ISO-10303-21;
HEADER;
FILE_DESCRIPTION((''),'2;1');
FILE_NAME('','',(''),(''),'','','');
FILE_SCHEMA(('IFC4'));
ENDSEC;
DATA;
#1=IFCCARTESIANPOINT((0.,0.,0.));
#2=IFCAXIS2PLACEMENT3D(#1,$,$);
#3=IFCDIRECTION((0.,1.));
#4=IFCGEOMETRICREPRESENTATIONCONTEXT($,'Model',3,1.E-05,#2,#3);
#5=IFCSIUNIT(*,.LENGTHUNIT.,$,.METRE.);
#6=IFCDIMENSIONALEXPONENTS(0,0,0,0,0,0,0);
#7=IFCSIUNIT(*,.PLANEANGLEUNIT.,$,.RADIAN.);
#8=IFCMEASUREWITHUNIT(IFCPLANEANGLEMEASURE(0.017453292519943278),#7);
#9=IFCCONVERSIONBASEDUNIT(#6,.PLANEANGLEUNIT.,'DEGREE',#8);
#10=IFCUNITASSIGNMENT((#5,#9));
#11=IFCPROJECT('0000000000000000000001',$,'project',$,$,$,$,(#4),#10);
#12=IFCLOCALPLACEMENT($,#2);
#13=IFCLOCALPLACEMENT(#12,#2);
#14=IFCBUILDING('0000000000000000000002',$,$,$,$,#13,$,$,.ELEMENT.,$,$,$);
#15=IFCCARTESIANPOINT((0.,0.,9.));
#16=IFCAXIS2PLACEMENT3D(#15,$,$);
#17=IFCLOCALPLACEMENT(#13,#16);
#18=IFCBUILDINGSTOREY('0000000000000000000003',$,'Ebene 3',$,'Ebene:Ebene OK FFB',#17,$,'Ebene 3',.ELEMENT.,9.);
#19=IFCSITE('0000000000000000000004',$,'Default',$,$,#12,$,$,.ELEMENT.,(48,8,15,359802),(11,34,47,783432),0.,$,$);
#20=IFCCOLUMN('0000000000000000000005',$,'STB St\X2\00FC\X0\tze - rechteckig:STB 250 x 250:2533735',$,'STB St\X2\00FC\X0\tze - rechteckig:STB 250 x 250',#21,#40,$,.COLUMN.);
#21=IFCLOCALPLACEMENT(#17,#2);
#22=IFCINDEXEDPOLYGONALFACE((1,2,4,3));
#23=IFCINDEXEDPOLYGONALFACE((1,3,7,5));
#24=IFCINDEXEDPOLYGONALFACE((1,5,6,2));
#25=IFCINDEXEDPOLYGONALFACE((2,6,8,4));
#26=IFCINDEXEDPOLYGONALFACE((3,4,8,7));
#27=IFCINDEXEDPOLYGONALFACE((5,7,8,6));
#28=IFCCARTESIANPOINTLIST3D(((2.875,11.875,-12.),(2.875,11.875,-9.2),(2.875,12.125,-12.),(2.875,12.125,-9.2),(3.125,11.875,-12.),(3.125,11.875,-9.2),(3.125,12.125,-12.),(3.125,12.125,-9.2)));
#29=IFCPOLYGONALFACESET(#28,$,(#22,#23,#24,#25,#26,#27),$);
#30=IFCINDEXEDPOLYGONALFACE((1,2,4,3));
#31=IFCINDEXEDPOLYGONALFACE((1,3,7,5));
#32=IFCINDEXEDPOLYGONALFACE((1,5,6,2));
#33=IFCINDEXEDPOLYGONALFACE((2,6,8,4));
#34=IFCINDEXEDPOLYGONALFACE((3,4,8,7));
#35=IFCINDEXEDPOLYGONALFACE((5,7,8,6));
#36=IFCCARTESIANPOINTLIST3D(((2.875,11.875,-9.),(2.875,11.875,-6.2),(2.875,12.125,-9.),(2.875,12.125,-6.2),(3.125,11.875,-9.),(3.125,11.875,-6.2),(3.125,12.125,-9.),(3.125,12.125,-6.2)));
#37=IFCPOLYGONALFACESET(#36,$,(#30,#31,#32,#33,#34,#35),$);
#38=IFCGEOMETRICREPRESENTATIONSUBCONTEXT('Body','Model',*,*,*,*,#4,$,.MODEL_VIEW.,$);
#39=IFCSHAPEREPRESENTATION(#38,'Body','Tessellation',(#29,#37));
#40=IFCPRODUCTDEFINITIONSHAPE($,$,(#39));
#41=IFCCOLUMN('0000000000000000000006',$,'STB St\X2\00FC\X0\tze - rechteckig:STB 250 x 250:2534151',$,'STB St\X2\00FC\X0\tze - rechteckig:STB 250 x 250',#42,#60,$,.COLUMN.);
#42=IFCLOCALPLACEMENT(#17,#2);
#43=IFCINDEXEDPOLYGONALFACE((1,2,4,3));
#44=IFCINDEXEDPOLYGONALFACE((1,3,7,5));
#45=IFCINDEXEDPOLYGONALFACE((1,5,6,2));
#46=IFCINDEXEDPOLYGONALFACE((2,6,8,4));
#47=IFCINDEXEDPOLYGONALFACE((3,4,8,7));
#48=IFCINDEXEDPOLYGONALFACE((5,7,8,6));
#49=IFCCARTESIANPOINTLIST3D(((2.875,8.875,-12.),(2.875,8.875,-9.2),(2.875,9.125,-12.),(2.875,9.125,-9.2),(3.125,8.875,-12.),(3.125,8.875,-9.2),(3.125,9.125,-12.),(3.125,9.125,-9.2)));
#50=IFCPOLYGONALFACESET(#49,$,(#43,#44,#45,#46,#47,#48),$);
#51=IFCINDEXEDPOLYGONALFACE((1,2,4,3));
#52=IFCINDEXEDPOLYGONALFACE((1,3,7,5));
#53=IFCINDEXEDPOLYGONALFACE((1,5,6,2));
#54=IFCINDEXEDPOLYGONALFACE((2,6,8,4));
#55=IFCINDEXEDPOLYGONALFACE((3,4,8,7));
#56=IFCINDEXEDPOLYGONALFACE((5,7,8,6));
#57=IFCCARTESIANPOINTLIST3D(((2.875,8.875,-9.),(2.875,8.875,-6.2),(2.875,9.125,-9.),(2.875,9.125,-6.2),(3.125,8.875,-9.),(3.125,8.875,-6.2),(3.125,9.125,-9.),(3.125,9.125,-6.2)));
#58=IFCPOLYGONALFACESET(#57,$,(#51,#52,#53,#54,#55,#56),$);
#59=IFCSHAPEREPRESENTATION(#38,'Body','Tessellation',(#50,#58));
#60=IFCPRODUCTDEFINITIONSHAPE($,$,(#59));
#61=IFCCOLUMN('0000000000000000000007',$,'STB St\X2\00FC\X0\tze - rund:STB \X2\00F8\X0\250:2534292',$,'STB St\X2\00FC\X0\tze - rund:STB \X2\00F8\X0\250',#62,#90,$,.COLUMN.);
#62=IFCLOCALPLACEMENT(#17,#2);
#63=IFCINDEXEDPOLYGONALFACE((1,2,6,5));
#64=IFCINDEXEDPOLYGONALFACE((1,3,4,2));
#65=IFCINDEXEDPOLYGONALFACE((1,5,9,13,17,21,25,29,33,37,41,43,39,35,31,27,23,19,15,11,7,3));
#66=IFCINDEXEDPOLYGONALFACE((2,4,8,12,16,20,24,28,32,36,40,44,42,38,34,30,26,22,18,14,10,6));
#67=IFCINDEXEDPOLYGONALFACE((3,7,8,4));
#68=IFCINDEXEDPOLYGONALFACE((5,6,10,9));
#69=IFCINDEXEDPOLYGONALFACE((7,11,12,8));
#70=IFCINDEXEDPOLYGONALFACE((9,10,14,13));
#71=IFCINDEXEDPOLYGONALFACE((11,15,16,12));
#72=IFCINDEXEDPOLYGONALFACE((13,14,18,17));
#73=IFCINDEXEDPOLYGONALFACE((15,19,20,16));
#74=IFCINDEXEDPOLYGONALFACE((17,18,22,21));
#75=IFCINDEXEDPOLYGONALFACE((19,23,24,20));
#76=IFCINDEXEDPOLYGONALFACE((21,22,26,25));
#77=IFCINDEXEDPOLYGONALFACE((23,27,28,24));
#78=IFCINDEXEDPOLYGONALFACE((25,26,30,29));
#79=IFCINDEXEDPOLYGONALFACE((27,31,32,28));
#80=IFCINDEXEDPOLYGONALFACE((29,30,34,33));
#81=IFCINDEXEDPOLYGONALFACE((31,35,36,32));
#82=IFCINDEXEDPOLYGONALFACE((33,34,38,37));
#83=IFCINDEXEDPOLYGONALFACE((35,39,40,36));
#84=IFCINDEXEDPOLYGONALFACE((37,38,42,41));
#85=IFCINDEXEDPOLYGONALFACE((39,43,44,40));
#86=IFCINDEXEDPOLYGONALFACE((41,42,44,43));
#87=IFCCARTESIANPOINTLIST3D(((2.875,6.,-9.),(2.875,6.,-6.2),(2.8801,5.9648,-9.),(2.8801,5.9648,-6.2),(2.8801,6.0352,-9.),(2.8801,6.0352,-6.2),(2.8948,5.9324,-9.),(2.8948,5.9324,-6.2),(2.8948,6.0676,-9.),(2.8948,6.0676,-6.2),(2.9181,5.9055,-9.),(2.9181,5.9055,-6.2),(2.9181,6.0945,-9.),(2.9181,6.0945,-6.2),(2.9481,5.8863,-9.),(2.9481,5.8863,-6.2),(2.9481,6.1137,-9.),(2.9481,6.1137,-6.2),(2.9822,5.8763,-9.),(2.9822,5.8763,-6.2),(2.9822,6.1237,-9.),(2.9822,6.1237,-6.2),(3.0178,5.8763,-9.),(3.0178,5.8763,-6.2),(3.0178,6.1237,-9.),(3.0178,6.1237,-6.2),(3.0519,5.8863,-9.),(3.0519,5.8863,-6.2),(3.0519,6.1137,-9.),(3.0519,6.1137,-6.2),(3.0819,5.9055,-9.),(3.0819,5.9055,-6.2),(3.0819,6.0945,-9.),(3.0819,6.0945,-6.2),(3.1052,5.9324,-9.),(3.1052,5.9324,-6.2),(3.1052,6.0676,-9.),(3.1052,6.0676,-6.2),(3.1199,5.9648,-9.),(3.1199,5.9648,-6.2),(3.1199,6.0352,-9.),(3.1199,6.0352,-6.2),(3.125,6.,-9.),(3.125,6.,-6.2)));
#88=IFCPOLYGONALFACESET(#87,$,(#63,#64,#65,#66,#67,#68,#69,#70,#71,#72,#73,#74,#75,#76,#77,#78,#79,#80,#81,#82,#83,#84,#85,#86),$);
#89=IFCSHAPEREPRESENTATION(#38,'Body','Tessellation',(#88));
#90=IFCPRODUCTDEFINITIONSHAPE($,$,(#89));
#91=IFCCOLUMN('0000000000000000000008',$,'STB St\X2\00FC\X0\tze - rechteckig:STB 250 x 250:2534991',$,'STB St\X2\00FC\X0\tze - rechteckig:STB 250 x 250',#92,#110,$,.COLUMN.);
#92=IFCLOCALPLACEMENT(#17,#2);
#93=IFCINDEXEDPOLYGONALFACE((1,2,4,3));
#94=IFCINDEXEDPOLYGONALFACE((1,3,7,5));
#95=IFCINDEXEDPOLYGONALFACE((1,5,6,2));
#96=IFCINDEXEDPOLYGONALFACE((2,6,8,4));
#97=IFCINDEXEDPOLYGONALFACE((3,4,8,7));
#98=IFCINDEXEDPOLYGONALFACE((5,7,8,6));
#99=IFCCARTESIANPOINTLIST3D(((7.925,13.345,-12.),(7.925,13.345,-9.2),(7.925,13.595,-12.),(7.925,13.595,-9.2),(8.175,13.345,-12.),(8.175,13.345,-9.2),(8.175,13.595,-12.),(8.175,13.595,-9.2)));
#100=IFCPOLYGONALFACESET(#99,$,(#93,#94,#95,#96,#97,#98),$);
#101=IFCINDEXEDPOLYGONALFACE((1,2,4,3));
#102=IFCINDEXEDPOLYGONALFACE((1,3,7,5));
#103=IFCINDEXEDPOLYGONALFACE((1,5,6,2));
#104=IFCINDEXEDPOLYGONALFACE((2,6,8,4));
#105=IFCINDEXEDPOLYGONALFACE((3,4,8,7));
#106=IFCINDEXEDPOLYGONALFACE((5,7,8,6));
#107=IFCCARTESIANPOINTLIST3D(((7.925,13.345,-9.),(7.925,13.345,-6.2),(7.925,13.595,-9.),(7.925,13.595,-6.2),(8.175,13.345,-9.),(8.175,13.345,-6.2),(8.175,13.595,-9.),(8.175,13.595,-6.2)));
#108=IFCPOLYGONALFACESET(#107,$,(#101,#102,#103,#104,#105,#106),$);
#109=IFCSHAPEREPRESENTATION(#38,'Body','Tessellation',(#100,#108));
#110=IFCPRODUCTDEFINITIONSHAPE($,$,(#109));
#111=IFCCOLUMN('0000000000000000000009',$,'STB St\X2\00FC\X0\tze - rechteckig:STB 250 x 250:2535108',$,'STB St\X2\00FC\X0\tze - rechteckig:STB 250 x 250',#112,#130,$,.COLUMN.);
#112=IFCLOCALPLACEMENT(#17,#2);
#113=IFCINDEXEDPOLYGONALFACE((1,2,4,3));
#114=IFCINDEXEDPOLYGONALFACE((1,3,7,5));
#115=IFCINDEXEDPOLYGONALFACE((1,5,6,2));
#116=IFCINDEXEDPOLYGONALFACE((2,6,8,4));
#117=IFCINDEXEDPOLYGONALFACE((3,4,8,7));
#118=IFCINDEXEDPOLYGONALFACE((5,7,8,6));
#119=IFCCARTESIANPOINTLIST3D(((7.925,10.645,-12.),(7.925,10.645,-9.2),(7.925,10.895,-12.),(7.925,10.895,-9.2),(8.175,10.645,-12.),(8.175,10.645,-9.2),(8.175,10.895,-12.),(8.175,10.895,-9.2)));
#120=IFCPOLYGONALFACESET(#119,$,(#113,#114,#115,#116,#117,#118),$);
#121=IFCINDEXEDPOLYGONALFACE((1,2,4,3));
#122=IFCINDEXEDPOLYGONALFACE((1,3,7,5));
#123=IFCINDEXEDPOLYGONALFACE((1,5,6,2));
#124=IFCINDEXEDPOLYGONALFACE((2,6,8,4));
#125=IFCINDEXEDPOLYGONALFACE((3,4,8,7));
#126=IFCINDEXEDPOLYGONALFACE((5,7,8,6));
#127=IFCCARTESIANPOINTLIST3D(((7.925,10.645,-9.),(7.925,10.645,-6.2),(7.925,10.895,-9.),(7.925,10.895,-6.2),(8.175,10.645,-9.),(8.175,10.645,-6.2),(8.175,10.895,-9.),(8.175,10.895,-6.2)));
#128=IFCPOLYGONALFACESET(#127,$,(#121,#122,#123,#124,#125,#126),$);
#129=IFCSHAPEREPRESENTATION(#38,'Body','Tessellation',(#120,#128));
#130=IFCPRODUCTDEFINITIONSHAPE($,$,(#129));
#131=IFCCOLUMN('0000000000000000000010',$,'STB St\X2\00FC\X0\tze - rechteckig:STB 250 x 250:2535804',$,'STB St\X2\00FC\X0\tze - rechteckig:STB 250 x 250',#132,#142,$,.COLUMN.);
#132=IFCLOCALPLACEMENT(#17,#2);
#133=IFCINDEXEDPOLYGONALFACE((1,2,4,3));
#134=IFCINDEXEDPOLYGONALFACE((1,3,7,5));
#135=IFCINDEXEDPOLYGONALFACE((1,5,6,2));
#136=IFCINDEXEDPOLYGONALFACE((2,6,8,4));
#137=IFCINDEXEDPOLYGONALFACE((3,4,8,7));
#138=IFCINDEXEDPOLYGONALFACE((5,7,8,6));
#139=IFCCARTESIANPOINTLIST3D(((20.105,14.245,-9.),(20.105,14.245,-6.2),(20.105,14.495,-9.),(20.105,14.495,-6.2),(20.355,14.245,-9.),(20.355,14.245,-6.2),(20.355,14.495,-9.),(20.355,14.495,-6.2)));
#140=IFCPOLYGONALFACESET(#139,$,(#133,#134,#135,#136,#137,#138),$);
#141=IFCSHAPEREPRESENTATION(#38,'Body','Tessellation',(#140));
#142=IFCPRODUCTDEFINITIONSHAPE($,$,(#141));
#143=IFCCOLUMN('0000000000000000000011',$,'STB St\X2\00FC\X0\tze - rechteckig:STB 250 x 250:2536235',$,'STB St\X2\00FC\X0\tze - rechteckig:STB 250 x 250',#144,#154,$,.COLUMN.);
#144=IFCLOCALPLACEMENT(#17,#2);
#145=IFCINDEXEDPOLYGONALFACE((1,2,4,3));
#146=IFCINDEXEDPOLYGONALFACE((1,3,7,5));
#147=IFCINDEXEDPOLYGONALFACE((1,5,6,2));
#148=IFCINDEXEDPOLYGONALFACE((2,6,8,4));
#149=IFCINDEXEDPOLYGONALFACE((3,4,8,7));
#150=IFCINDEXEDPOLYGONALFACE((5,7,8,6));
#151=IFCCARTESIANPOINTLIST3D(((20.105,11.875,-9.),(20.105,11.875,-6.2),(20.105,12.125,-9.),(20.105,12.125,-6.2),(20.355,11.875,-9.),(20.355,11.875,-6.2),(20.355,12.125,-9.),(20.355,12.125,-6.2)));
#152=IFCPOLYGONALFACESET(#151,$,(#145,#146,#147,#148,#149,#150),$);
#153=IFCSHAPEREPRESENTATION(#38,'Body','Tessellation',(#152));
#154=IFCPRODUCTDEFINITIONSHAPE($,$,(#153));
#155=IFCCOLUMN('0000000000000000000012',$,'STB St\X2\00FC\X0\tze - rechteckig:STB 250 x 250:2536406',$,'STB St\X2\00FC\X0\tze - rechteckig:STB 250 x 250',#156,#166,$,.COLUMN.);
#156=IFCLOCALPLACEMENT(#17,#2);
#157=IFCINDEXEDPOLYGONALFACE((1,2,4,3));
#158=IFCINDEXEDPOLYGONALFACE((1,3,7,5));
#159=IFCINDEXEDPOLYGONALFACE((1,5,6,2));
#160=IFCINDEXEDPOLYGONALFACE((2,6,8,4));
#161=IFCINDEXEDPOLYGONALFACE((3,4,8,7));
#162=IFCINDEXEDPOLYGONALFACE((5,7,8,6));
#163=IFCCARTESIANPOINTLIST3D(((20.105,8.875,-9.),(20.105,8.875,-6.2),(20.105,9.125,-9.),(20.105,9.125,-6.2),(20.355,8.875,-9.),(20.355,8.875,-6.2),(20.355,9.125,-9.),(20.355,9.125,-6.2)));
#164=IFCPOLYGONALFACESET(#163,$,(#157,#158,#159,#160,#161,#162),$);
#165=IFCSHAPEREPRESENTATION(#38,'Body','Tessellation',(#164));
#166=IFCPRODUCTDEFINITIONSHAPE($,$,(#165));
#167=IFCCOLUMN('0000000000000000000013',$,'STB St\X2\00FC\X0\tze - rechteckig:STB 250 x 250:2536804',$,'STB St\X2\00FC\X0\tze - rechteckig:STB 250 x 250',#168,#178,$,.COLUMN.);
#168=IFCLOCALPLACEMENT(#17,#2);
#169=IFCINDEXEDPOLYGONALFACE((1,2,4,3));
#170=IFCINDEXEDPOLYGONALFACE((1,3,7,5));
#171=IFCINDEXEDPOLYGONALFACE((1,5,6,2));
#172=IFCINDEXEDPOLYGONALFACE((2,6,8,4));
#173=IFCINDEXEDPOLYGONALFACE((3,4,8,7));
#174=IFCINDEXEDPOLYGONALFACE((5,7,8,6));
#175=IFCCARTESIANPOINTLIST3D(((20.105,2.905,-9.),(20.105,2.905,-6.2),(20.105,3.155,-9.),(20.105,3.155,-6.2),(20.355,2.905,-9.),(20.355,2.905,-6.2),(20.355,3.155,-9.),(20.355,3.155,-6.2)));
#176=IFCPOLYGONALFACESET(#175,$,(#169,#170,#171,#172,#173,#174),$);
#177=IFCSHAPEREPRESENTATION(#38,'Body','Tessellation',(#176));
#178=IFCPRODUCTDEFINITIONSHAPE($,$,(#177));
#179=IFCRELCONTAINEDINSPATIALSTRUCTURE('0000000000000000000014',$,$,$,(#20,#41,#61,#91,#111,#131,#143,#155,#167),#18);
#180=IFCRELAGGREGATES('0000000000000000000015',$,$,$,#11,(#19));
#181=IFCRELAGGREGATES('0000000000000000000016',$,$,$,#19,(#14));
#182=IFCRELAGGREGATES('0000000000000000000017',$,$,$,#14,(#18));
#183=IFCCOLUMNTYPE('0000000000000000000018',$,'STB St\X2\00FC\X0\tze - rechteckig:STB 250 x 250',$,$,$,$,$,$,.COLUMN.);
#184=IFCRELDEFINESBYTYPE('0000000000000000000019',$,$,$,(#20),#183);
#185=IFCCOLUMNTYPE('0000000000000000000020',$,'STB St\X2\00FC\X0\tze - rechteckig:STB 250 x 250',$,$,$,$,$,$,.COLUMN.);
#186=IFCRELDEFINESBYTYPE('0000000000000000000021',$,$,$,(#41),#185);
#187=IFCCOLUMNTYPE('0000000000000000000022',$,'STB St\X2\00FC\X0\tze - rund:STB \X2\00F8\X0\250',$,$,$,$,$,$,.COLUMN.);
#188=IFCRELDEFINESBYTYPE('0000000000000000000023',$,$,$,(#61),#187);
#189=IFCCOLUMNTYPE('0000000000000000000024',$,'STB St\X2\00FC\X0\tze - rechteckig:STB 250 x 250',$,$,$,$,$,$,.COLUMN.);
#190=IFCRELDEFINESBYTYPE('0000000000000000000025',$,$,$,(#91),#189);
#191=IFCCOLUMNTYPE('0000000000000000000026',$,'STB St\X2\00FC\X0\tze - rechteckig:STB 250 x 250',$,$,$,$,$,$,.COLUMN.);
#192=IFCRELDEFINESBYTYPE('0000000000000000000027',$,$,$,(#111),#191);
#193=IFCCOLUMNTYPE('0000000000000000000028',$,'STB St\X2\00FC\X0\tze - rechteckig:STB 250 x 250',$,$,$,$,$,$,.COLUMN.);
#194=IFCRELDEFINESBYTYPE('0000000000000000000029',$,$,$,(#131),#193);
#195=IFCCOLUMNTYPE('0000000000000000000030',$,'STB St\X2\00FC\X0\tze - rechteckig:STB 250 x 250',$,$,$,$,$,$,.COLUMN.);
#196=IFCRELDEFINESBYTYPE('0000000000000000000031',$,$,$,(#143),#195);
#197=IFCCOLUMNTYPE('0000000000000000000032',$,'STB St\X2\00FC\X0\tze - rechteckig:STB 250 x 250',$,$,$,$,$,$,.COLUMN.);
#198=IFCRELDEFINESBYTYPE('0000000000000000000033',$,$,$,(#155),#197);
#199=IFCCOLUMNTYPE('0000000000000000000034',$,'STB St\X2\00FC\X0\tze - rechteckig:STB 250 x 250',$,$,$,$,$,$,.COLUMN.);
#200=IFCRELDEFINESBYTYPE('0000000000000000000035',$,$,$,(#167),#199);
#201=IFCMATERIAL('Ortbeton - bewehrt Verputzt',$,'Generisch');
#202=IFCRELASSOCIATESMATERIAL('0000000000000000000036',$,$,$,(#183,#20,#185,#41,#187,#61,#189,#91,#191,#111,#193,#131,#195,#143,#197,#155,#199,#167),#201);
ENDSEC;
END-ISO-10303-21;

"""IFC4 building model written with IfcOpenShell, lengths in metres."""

from ifc_helpers import new_model, entity, si_unit, converted_unit, direction, frame, origin, place, context, subcontext, project, spatial, arc, indexed_curve, outline, extrude, source, transform, mapped, material, type_object, type_shapes, element, save


model = new_model("IFC4")

# Units and contexts
model_context = context("Model", 3, precision=1e-05, world=origin(), true_north=direction((0.0, 1.0)))
body_context = subcontext(model_context, "Body", "Model", "MODEL_VIEW")
ifc_project = project(units=[si_unit("LENGTHUNIT", "METRE"), converted_unit("PLANEANGLEUNIT", "DEGREE", entity("IfcPlaneAngleMeasure", 0.017453292519943278), si_unit("PLANEANGLEUNIT", "RADIAN"), dimensions=[0, 0, 0, 0, 0, 0, 0])], contexts=[model_context])

# Site, building, storey
site_placement = place(None, origin())
site = spatial("IfcSite", under=ifc_project, at=site_placement, Name="Default", CompositionType="ELEMENT", RefLatitude=(48, 8, 15, 359802), RefLongitude=(11, 34, 47, 783432), RefElevation=0.0)
building_placement = place(site_placement, origin())
building = spatial("IfcBuilding", under=site, at=building_placement, CompositionType="ELEMENT")
storey_placement = place(building_placement, frame((0.0, 0.0, 9.0)))
storey = spatial("IfcBuildingStorey", under=building, at=storey_placement, Name="Ebene 3", ObjectType="Ebene:Ebene OK FFB", LongName="Ebene 3", CompositionType="ELEMENT", Elevation=9.0)

# Columns
ifc_material_1 = material(Name="Ortbeton - bewehrt Verputzt", Category="Generisch")
column_type_1 = type_object("IfcColumnType", Name="STB Stütze - rechteckig:STB 250 x 250", PredefinedType="COLUMN", material=ifc_material_1)
shared_shape_1 = source(origin(), body_context, "Body", "SweptSolid", [
    extrude(outline(indexed_curve([(-0.125, -0.125), (0.125, -0.125), (0.125, 0.125), (-0.125, 0.125), (-0.125, -0.125)], self_intersect=False)), frame((3.0, 12.0, -3.0), z_axis=(0.0, 0.0, 1.0), x_axis=(-1.0, 0.0, 0.0)), (0.0, 0.0, 1.0), 2.8),
    extrude(outline(indexed_curve([(-0.125, -0.125), (0.125, -0.125), (0.125, 0.125), (-0.125, 0.125), (-0.125, -0.125)], self_intersect=False)), frame((3.0, 12.0, 0.0), z_axis=(0.0, 0.0, 1.0), x_axis=(0.0, -1.0, 0.0)), (0.0, 0.0, 1.0), 2.8),
])
type_shapes(column_type_1, [shared_shape_1])
column_1_placement = place(storey_placement, frame((0.0, 0.0, -9.0)))
element("IfcColumn", 1, at=column_1_placement, inside=storey, type_object=column_type_1, material=ifc_material_1, Name="STB Stütze - rechteckig:STB 250 x 250:2533735", ObjectType="STB Stütze - rechteckig:STB 250 x 250", PredefinedType="COLUMN", context=body_context, shape_type="MappedRepresentation", body=[
    mapped(shared_shape_1, transform((0.0, 0.0, 0.0), scale=1.0)),
])
column_type_2 = type_object("IfcColumnType", Name="STB Stütze - rechteckig:STB 250 x 250", PredefinedType="COLUMN", material=ifc_material_1)
shared_shape_2 = source(origin(), body_context, "Body", "SweptSolid", [
    extrude(outline(indexed_curve([(-0.125, -0.125), (0.125, -0.125), (0.125, 0.125), (-0.125, 0.125), (-0.125, -0.125)], self_intersect=False)), frame((3.0, 9.0, -3.0), z_axis=(0.0, 0.0, 1.0), x_axis=(-1.0, 0.0, 0.0)), (0.0, 0.0, 1.0), 2.8),
    extrude(outline(indexed_curve([(-0.125, -0.125), (0.125, -0.125), (0.125, 0.125), (-0.125, 0.125), (-0.125, -0.125)], self_intersect=False)), frame((3.0, 9.0, 0.0), z_axis=(0.0, 0.0, 1.0), x_axis=(0.0, -1.0, 0.0)), (0.0, 0.0, 1.0), 2.8),
])
type_shapes(column_type_2, [shared_shape_2])
column_2_placement = place(storey_placement, frame((0.0, 0.0, -9.0)))
element("IfcColumn", 2, at=column_2_placement, inside=storey, type_object=column_type_2, material=ifc_material_1, Name="STB Stütze - rechteckig:STB 250 x 250:2534151", ObjectType="STB Stütze - rechteckig:STB 250 x 250", PredefinedType="COLUMN", context=body_context, shape_type="MappedRepresentation", body=[
    mapped(shared_shape_2, transform((0.0, 0.0, 0.0), scale=1.0)),
])
column_type_3 = type_object("IfcColumnType", Name="STB Stütze - rund:STB ø250", PredefinedType="COLUMN", material=ifc_material_1)
shared_shape_3 = source(origin(), body_context, "Body", "SweptSolid", [
    extrude(outline(indexed_curve([(0.125, 0.0), (0.0, 0.125), (-0.125, 0.0), (0.0, -0.125)], segments=[arc(1, 2, 3), arc(3, 4, 1)], self_intersect=False)), frame((3.0, 6.0, 0.0)), (0.0, 0.0, 1.0), 2.8),
])
type_shapes(column_type_3, [shared_shape_3])
column_3_placement = place(storey_placement, frame((0.0, 0.0, -9.0)))
element("IfcColumn", 3, at=column_3_placement, inside=storey, type_object=column_type_3, material=ifc_material_1, Name="STB Stütze - rund:STB ø250:2534292", ObjectType="STB Stütze - rund:STB ø250", PredefinedType="COLUMN", context=body_context, shape_type="MappedRepresentation", body=[
    mapped(shared_shape_3, transform((0.0, 0.0, 0.0), scale=1.0)),
])
column_type_4 = type_object("IfcColumnType", Name="STB Stütze - rechteckig:STB 250 x 250", PredefinedType="COLUMN", material=ifc_material_1)
shared_shape_4 = source(origin(), body_context, "Body", "SweptSolid", [
    extrude(outline(indexed_curve([(-0.125, -0.125), (0.125, -0.125), (0.125, 0.125), (-0.125, 0.125), (-0.125, -0.125)], self_intersect=False)), frame((8.05, 13.47, -3.0), z_axis=(0.0, 0.0, 1.0), x_axis=(-1.0, 0.0, 0.0)), (0.0, 0.0, 1.0), 2.8),
    extrude(outline(indexed_curve([(-0.125, -0.125), (0.125, -0.125), (0.125, 0.125), (-0.125, 0.125), (-0.125, -0.125)], self_intersect=False)), frame((8.05, 13.47, 0.0), z_axis=(0.0, 0.0, 1.0), x_axis=(0.0, -1.0, 0.0)), (0.0, 0.0, 1.0), 2.8),
])
type_shapes(column_type_4, [shared_shape_4])
column_4_placement = place(storey_placement, frame((0.0, 0.0, -9.0)))
element("IfcColumn", 4, at=column_4_placement, inside=storey, type_object=column_type_4, material=ifc_material_1, Name="STB Stütze - rechteckig:STB 250 x 250:2534991", ObjectType="STB Stütze - rechteckig:STB 250 x 250", PredefinedType="COLUMN", context=body_context, shape_type="MappedRepresentation", body=[
    mapped(shared_shape_4, transform((0.0, 0.0, 0.0), scale=1.0)),
])
column_type_5 = type_object("IfcColumnType", Name="STB Stütze - rechteckig:STB 250 x 250", PredefinedType="COLUMN", material=ifc_material_1)
shared_shape_5 = source(origin(), body_context, "Body", "SweptSolid", [
    extrude(outline(indexed_curve([(-0.125, -0.125), (0.125, -0.125), (0.125, 0.125), (-0.125, 0.125), (-0.125, -0.125)], self_intersect=False)), frame((8.05, 10.77, -3.0), z_axis=(0.0, 0.0, 1.0), x_axis=(-1.0, 0.0, 0.0)), (0.0, 0.0, 1.0), 2.8),
    extrude(outline(indexed_curve([(-0.125, -0.125), (0.125, -0.125), (0.125, 0.125), (-0.125, 0.125), (-0.125, -0.125)], self_intersect=False)), frame((8.05, 10.77, 0.0), z_axis=(0.0, 0.0, 1.0), x_axis=(0.0, -1.0, 0.0)), (0.0, 0.0, 1.0), 2.8),
])
type_shapes(column_type_5, [shared_shape_5])
column_5_placement = place(storey_placement, frame((0.0, 0.0, -9.0)))
element("IfcColumn", 5, at=column_5_placement, inside=storey, type_object=column_type_5, material=ifc_material_1, Name="STB Stütze - rechteckig:STB 250 x 250:2535108", ObjectType="STB Stütze - rechteckig:STB 250 x 250", PredefinedType="COLUMN", context=body_context, shape_type="MappedRepresentation", body=[
    mapped(shared_shape_5, transform((0.0, 0.0, 0.0), scale=1.0)),
])
column_type_6 = type_object("IfcColumnType", Name="STB Stütze - rechteckig:STB 250 x 250", PredefinedType="COLUMN", material=ifc_material_1)
shared_shape_6 = source(origin(), body_context, "Body", "SweptSolid", [
    extrude(outline(indexed_curve([(-0.125, -0.125), (0.125, -0.125), (0.125, 0.125), (-0.125, 0.125), (-0.125, -0.125)], self_intersect=False)), frame((20.23, 14.37, 0.0), z_axis=(0.0, 0.0, 1.0), x_axis=(-1.0, 0.0, 0.0)), (0.0, 0.0, 1.0), 2.8),
])
type_shapes(column_type_6, [shared_shape_6])
column_6_placement = place(storey_placement, frame((0.0, 0.0, -9.0)))
element("IfcColumn", 6, at=column_6_placement, inside=storey, type_object=column_type_6, material=ifc_material_1, Name="STB Stütze - rechteckig:STB 250 x 250:2535804", ObjectType="STB Stütze - rechteckig:STB 250 x 250", PredefinedType="COLUMN", context=body_context, shape_type="MappedRepresentation", body=[
    mapped(shared_shape_6, transform((0.0, 0.0, 0.0), scale=1.0)),
])
column_type_7 = type_object("IfcColumnType", Name="STB Stütze - rechteckig:STB 250 x 250", PredefinedType="COLUMN", material=ifc_material_1)
shared_shape_7 = source(origin(), body_context, "Body", "SweptSolid", [
    extrude(outline(indexed_curve([(-0.125, -0.125), (0.125, -0.125), (0.125, 0.125), (-0.125, 0.125), (-0.125, -0.125)], self_intersect=False)), frame((20.23, 12.0, 0.0), z_axis=(0.0, 0.0, 1.0), x_axis=(-1.0, 0.0, 0.0)), (0.0, 0.0, 1.0), 2.8),
])
type_shapes(column_type_7, [shared_shape_7])
column_7_placement = place(storey_placement, frame((0.0, 0.0, -9.0)))
element("IfcColumn", 7, at=column_7_placement, inside=storey, type_object=column_type_7, material=ifc_material_1, Name="STB Stütze - rechteckig:STB 250 x 250:2536235", ObjectType="STB Stütze - rechteckig:STB 250 x 250", PredefinedType="COLUMN", context=body_context, shape_type="MappedRepresentation", body=[
    mapped(shared_shape_7, transform((0.0, 0.0, 0.0), scale=1.0)),
])
column_type_8 = type_object("IfcColumnType", Name="STB Stütze - rechteckig:STB 250 x 250", PredefinedType="COLUMN", material=ifc_material_1)
shared_shape_8 = source(origin(), body_context, "Body", "SweptSolid", [
    extrude(outline(indexed_curve([(-0.125, -0.125), (0.125, -0.125), (0.125, 0.125), (-0.125, 0.125), (-0.125, -0.125)], self_intersect=False)), frame((20.23, 9.0, 0.0), z_axis=(0.0, 0.0, 1.0), x_axis=(-1.0, 0.0, 0.0)), (0.0, 0.0, 1.0), 2.8),
])
type_shapes(column_type_8, [shared_shape_8])
column_8_placement = place(storey_placement, frame((0.0, 0.0, -9.0)))
element("IfcColumn", 8, at=column_8_placement, inside=storey, type_object=column_type_8, material=ifc_material_1, Name="STB Stütze - rechteckig:STB 250 x 250:2536406", ObjectType="STB Stütze - rechteckig:STB 250 x 250", PredefinedType="COLUMN", context=body_context, shape_type="MappedRepresentation", body=[
    mapped(shared_shape_8, transform((0.0, 0.0, 0.0), scale=1.0)),
])
column_type_9 = type_object("IfcColumnType", Name="STB Stütze - rechteckig:STB 250 x 250", PredefinedType="COLUMN", material=ifc_material_1)
shared_shape_9 = source(origin(), body_context, "Body", "SweptSolid", [
    extrude(outline(indexed_curve([(-0.125, -0.125), (0.125, -0.125), (0.125, 0.125), (-0.125, 0.125), (-0.125, -0.125)], self_intersect=False)), frame((20.23, 3.03, 0.0), z_axis=(0.0, 0.0, 1.0), x_axis=(-1.0, 0.0, 0.0)), (0.0, 0.0, 1.0), 2.8),
])
type_shapes(column_type_9, [shared_shape_9])
column_9_placement = place(storey_placement, frame((0.0, 0.0, -9.0)))
element("IfcColumn", 9, at=column_9_placement, inside=storey, type_object=column_type_9, material=ifc_material_1, Name="STB Stütze - rechteckig:STB 250 x 250:2536804", ObjectType="STB Stütze - rechteckig:STB 250 x 250", PredefinedType="COLUMN", context=body_context, shape_type="MappedRepresentation", body=[
    mapped(shared_shape_9, transform((0.0, 0.0, 0.0), scale=1.0)),
])

save(model, "model.ifc")
